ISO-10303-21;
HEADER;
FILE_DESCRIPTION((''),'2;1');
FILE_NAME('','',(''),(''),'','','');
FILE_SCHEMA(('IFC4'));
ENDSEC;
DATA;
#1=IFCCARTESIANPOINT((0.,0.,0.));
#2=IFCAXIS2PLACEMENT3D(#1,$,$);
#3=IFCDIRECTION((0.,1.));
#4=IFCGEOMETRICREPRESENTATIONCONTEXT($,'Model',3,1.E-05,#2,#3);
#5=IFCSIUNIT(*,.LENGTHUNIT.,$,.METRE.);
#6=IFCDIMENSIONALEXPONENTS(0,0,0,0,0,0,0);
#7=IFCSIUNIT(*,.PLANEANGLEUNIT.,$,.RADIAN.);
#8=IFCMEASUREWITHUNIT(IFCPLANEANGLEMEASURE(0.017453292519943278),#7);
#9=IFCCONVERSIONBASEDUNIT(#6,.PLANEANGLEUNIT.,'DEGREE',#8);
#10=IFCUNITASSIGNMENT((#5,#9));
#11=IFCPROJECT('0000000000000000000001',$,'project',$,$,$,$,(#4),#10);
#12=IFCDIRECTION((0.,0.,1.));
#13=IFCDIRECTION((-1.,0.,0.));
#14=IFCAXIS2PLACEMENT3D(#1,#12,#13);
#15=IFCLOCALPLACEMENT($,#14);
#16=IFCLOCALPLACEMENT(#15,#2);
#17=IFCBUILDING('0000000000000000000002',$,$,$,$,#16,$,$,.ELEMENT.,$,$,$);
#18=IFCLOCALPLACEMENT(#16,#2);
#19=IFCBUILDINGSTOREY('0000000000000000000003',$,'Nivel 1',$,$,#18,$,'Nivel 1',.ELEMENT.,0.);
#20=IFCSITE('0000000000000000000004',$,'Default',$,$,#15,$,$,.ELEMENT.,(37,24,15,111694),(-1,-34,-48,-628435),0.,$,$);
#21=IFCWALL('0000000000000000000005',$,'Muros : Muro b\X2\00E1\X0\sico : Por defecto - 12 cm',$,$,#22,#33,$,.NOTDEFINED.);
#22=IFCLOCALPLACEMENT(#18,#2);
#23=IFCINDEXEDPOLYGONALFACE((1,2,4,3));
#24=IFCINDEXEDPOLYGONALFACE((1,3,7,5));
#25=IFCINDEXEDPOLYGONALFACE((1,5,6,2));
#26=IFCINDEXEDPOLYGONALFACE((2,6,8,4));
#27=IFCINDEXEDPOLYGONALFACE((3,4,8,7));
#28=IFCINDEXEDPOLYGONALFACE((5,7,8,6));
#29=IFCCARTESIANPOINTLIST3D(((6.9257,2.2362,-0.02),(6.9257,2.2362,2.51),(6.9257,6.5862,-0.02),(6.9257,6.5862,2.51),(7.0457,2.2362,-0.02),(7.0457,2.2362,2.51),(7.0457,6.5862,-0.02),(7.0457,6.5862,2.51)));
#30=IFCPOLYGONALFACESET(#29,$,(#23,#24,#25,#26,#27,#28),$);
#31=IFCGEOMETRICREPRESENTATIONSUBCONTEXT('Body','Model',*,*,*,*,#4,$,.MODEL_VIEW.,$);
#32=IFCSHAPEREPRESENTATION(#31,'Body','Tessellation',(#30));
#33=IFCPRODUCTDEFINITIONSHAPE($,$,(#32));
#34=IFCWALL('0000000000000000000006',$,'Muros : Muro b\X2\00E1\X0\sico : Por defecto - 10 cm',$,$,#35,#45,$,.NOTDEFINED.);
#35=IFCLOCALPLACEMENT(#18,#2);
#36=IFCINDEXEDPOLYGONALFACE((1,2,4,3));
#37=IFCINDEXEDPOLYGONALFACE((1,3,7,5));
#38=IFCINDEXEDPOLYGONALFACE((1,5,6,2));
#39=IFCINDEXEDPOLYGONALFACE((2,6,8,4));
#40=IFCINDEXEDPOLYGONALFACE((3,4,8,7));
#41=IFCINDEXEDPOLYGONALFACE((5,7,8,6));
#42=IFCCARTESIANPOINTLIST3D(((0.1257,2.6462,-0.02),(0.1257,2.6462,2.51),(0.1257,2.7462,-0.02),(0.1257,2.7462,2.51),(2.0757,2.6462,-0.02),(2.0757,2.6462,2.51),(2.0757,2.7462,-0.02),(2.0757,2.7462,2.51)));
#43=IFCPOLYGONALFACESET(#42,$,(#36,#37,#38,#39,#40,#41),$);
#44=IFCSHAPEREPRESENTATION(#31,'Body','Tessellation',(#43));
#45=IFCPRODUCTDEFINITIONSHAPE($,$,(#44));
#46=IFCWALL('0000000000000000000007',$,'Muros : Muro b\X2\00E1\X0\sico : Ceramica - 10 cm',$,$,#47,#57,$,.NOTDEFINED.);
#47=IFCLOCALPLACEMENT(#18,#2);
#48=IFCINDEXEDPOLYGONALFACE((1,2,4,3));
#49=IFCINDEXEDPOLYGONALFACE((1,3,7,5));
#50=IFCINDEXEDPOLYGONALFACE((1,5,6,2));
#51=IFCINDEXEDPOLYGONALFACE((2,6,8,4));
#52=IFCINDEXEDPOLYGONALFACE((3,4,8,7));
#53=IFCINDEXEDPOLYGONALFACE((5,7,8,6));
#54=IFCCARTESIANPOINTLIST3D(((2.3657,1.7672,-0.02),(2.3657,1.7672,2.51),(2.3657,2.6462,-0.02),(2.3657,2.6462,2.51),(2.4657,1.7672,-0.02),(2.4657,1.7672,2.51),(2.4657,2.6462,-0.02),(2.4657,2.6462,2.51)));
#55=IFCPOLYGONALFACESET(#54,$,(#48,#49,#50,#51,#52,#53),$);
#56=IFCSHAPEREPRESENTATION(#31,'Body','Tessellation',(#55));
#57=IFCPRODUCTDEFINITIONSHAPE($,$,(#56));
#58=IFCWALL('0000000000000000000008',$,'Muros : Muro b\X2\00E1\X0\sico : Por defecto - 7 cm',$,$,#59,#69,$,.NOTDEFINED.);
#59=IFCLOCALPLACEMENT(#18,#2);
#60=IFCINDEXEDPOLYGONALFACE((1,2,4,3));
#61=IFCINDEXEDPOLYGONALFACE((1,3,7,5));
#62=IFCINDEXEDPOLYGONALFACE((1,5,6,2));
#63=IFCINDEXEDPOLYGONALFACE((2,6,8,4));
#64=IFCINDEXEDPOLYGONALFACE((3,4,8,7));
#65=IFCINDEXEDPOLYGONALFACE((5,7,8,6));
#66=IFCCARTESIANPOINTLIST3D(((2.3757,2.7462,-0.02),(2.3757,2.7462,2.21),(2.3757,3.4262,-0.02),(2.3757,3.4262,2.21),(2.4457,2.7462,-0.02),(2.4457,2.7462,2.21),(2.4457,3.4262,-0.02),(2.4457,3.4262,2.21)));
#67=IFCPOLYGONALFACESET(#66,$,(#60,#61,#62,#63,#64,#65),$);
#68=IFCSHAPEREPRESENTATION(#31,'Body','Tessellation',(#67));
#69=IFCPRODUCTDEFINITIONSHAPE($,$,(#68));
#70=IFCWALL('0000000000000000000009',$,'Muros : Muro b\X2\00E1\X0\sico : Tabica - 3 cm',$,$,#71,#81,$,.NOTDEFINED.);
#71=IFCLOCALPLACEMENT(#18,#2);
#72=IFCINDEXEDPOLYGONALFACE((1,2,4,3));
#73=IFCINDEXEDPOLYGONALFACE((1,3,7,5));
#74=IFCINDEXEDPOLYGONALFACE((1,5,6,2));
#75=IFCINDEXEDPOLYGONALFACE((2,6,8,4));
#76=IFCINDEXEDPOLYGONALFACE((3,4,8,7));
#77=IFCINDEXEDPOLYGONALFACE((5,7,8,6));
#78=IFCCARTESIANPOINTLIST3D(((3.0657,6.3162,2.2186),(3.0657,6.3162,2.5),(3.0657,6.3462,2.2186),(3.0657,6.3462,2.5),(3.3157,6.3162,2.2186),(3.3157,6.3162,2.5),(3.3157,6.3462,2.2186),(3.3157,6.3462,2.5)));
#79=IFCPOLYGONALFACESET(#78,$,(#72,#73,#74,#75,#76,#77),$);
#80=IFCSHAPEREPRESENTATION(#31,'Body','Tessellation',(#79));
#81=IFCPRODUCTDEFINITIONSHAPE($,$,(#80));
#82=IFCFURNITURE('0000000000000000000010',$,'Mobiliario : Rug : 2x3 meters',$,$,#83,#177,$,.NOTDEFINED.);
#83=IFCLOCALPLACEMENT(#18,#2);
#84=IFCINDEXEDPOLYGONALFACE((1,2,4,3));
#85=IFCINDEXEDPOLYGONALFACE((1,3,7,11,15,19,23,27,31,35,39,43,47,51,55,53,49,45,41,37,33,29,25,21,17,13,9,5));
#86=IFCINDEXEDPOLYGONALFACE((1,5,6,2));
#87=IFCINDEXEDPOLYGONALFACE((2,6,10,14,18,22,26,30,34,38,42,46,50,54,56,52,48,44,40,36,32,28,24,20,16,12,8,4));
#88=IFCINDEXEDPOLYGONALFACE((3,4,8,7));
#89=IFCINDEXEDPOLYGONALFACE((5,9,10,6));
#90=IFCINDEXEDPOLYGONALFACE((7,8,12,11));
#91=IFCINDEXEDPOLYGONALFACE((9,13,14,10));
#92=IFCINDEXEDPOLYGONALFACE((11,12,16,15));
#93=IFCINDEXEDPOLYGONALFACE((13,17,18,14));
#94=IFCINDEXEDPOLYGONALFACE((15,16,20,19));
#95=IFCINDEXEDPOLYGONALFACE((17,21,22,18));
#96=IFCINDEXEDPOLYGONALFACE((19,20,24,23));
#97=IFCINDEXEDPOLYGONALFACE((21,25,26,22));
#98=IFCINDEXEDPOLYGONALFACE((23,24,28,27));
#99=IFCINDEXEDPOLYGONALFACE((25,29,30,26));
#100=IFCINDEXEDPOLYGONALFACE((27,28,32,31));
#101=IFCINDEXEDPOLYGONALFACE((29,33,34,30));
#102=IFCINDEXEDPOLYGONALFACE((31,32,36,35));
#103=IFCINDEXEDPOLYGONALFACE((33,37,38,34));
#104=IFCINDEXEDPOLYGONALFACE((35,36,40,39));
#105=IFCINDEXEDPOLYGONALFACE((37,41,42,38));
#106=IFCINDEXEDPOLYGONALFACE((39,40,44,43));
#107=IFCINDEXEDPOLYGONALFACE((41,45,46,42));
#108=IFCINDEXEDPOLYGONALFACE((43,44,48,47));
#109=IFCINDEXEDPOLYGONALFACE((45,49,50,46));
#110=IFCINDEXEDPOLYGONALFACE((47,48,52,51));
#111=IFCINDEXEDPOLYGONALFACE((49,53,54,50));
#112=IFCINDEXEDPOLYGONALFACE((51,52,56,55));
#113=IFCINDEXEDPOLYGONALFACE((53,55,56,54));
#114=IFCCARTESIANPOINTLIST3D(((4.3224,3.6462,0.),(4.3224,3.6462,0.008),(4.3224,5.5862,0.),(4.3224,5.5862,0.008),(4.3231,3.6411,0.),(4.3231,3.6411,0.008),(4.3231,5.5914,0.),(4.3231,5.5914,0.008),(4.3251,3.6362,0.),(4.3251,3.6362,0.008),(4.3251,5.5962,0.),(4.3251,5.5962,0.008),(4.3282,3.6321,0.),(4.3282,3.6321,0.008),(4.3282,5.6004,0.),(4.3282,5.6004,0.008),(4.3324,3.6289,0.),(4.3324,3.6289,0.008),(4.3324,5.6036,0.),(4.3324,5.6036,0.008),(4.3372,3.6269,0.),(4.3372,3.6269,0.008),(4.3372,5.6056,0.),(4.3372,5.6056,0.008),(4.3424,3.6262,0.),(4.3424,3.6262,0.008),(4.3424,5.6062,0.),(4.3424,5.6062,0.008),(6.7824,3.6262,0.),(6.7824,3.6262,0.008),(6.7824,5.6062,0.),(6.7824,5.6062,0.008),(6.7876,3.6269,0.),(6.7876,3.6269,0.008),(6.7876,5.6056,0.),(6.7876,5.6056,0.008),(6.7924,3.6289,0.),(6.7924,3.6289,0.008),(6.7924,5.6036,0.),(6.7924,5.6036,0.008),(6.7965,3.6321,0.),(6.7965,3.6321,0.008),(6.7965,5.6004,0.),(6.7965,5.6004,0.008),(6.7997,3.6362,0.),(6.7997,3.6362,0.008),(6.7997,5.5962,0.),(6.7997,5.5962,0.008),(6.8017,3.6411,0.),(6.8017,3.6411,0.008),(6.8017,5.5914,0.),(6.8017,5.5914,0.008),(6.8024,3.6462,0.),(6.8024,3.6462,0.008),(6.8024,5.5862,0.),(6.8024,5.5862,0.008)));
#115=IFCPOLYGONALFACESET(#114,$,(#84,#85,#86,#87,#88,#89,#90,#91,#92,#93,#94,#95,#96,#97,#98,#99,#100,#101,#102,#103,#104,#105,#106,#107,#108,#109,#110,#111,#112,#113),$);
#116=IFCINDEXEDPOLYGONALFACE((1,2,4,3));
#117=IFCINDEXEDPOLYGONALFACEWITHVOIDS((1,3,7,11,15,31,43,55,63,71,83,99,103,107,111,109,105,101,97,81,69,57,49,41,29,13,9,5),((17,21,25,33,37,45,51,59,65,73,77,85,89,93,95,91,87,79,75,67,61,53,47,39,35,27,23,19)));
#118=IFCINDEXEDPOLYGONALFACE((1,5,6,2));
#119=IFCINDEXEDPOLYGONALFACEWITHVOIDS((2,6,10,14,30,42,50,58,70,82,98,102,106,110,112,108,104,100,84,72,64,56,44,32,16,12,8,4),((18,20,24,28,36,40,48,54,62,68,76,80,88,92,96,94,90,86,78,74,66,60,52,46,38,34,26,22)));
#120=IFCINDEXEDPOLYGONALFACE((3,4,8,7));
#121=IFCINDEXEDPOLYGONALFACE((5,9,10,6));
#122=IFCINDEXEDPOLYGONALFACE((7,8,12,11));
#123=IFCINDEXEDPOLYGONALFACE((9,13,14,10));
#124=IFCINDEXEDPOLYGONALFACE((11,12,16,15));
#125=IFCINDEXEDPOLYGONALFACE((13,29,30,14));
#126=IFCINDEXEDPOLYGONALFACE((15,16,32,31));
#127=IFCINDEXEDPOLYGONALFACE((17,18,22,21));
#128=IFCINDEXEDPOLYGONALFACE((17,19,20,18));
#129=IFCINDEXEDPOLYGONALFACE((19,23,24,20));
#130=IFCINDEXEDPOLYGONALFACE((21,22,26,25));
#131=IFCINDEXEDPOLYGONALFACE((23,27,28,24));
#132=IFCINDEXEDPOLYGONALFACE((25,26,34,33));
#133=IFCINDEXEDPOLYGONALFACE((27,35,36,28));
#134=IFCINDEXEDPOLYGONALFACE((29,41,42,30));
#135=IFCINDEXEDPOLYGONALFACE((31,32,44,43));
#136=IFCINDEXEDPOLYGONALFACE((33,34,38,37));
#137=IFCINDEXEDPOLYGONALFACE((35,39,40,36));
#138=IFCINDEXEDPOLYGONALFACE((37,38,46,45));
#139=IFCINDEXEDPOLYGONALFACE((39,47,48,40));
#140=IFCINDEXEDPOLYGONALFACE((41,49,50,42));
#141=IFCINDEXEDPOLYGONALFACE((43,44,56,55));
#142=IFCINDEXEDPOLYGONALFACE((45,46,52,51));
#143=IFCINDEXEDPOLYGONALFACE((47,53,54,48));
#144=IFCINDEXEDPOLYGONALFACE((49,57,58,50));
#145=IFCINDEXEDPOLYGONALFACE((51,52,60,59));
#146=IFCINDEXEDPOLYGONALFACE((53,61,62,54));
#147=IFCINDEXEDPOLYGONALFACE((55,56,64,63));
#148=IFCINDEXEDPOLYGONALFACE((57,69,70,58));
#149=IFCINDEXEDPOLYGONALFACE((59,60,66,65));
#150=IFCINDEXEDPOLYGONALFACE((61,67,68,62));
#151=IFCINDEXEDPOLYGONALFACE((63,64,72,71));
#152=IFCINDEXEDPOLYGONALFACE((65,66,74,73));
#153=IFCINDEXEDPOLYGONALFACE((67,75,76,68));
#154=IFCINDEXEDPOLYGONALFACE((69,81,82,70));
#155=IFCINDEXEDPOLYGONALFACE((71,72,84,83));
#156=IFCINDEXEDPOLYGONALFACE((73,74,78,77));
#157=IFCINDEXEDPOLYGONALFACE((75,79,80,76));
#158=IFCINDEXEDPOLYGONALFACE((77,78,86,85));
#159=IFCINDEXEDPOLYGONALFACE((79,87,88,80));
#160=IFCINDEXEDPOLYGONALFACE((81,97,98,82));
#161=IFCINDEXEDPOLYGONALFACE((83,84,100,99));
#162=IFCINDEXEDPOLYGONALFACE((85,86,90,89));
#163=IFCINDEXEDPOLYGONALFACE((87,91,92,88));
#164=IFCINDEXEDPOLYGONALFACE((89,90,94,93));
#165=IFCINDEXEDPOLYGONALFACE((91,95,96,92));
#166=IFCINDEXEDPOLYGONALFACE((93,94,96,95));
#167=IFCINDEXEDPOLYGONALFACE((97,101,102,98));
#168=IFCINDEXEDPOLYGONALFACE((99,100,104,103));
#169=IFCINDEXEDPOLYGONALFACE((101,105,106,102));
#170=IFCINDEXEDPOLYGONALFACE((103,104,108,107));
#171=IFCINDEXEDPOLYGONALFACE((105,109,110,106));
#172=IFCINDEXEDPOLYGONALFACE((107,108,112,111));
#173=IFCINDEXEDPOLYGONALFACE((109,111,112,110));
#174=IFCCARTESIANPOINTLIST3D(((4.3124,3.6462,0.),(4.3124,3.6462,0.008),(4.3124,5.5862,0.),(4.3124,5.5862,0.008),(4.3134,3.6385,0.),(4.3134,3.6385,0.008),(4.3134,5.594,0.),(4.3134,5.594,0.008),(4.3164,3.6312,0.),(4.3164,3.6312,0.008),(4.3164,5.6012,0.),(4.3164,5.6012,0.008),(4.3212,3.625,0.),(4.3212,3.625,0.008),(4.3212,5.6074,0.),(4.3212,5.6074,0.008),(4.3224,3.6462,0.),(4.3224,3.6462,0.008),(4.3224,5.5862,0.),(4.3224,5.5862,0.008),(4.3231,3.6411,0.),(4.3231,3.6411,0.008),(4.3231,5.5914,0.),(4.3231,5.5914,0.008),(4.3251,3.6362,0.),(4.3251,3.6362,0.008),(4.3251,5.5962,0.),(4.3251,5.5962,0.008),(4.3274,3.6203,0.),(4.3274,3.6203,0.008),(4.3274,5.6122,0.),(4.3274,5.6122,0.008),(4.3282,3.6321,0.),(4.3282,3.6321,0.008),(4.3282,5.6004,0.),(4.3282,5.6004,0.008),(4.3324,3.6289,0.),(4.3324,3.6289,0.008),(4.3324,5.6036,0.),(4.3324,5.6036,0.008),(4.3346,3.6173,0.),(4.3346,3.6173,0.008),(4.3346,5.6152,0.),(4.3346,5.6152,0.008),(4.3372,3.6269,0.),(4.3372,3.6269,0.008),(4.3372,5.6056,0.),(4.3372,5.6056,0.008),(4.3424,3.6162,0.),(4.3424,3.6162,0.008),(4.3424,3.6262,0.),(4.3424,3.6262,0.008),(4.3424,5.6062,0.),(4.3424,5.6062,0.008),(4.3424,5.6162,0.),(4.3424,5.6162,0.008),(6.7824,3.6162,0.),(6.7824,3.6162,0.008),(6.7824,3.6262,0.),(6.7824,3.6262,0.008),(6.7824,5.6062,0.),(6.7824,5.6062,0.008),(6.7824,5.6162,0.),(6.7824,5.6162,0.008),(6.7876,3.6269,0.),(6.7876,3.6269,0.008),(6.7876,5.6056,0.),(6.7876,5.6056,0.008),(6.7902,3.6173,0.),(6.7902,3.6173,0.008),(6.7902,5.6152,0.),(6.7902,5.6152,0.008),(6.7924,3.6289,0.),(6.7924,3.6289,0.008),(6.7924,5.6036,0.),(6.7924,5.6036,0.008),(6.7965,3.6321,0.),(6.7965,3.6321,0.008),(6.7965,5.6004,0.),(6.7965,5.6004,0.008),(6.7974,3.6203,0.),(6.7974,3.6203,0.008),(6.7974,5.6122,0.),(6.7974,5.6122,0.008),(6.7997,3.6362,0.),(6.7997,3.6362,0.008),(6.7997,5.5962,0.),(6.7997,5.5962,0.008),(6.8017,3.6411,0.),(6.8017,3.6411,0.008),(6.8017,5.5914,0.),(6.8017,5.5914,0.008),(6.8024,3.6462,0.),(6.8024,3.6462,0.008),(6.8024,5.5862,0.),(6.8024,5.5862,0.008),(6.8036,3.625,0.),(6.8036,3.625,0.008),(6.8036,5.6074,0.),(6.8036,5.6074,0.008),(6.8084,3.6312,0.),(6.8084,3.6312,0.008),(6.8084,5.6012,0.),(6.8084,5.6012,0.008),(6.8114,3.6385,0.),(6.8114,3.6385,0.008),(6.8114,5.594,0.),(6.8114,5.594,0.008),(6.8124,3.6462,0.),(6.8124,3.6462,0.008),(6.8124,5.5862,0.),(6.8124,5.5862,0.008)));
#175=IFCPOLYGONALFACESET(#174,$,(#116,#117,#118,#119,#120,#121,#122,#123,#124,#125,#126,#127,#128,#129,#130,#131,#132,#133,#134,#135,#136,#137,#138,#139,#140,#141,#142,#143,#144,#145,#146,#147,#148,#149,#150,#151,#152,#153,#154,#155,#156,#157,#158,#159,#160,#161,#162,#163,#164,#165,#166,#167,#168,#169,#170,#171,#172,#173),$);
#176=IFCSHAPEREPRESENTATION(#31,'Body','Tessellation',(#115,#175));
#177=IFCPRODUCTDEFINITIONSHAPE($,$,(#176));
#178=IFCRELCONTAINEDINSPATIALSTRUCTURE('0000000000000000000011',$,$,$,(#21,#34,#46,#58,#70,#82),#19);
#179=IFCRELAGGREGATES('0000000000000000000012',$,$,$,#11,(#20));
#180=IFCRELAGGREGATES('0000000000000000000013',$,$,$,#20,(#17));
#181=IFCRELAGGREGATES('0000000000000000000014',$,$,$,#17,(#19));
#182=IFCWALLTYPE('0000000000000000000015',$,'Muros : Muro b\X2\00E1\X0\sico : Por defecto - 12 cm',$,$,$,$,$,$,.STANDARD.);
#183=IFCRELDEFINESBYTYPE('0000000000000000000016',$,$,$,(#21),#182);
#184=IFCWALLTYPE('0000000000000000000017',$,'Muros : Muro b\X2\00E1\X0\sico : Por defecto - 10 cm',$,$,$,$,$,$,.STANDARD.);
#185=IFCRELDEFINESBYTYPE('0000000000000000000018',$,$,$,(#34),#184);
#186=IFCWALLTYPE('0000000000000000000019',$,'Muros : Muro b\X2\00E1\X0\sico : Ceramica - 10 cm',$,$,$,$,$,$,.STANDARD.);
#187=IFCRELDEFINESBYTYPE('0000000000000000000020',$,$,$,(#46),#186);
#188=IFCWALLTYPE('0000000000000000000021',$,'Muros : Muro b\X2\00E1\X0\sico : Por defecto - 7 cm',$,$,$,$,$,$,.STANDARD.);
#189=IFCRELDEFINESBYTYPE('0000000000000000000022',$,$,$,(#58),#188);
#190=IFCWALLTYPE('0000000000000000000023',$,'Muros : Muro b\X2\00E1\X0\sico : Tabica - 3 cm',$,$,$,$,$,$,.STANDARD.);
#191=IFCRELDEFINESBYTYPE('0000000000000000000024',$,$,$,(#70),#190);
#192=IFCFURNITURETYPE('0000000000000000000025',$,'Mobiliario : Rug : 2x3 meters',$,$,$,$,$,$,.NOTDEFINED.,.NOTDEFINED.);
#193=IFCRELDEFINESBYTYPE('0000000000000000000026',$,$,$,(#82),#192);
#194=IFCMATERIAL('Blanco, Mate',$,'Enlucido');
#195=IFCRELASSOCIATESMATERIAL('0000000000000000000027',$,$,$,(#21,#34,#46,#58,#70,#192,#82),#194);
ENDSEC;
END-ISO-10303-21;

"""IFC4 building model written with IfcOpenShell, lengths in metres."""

from ifc_helpers import new_model, entity, si_unit, converted_unit, direction, frame, origin, place, context, subcontext, project, spatial, line, arc, indexed_curve, outline, extrude, source, transform, mapped, material, type_object, type_shapes, element, save


model = new_model("IFC4")

# Units and contexts
model_context = context("Model", 3, precision=1e-05, world=origin(), true_north=direction((0.0, 1.0)))
body_context = subcontext(model_context, "Body", "Model", "MODEL_VIEW")
ifc_project = project(units=[si_unit("LENGTHUNIT", "METRE"), converted_unit("PLANEANGLEUNIT", "DEGREE", entity("IfcPlaneAngleMeasure", 0.017453292519943278), si_unit("PLANEANGLEUNIT", "RADIAN"), dimensions=[0, 0, 0, 0, 0, 0, 0])], contexts=[model_context])

# Site, building, storey
site_placement = place(None, frame((0.0, 0.0, 0.0), z_axis=(0.0, 0.0, 1.0), x_axis=(-1.0, 0.0, 0.0)))
site = spatial("IfcSite", under=ifc_project, at=site_placement, Name="Default", CompositionType="ELEMENT", RefLatitude=(37, 24, 15, 111694), RefLongitude=(-1, -34, -48, -628435), RefElevation=0.0)
building_placement = place(site_placement, origin())
building = spatial("IfcBuilding", under=site, at=building_placement, CompositionType="ELEMENT")
storey_placement = place(building_placement, origin())
storey = spatial("IfcBuildingStorey", under=building, at=storey_placement, Name="Nivel 1", LongName="Nivel 1", CompositionType="ELEMENT", Elevation=0.0)

# Walls
ifc_material_1 = material(Name="Blanco, Mate", Category="Enlucido")
wall_type_1 = type_object("IfcWallType", Name="Muros : Muro básico : Por defecto - 12 cm", PredefinedType="STANDARD")
wall_1_placement = place(storey_placement, frame((6.9857, 6.5862, -0.02), z_axis=(0.0, 0.0, 1.0), x_axis=(0.0, -1.0, 0.0)))
element("IfcWall", 1, at=wall_1_placement, inside=storey, type_object=wall_type_1, material=ifc_material_1, Name="Muros : Muro básico : Por defecto - 12 cm", PredefinedType="NOTDEFINED", context=body_context, shape_type="SweptSolid", body=[
    extrude(outline(indexed_curve([(4.35, 0.06), (0.0, 0.06), (0.0, -0.06), (4.35, -0.06), (4.35, 0.06)], self_intersect=False)), origin(), (0.0, 0.0, 1.0), 2.53),
])
wall_type_2 = type_object("IfcWallType", Name="Muros : Muro básico : Por defecto - 10 cm", PredefinedType="STANDARD")
wall_2_placement = place(storey_placement, frame((2.0757, 2.6962, -0.02), z_axis=(0.0, 0.0, 1.0), x_axis=(-1.0, 0.0, 0.0)))
element("IfcWall", 2, at=wall_2_placement, inside=storey, type_object=wall_type_2, material=ifc_material_1, Name="Muros : Muro básico : Por defecto - 10 cm", PredefinedType="NOTDEFINED", context=body_context, shape_type="SweptSolid", body=[
    extrude(outline(indexed_curve([(1.95, 0.05), (0.0, 0.05), (0.0, -0.05), (1.95, -0.05), (1.95, 0.05)], self_intersect=False)), origin(), (0.0, 0.0, 1.0), 2.53),
])
wall_type_3 = type_object("IfcWallType", Name="Muros : Muro básico : Ceramica - 10 cm", PredefinedType="STANDARD")
wall_3_placement = place(storey_placement, frame((2.4157, 2.6462, -0.02), z_axis=(0.0, 0.0, 1.0), x_axis=(0.0, -1.0, 0.0)))
element("IfcWall", 3, at=wall_3_placement, inside=storey, type_object=wall_type_3, material=ifc_material_1, Name="Muros : Muro básico : Ceramica - 10 cm", PredefinedType="NOTDEFINED", context=body_context, shape_type="SweptSolid", body=[
    extrude(outline(indexed_curve([(0.8791, 0.05), (0.0, 0.05), (0.0, -0.05), (0.8791, -0.05), (0.8791, 0.05)], self_intersect=False)), origin(), (0.0, 0.0, 1.0), 2.53),
])
wall_type_4 = type_object("IfcWallType", Name="Muros : Muro básico : Por defecto - 7 cm", PredefinedType="STANDARD")
wall_4_placement = place(storey_placement, frame((2.4107, 2.7462, -0.02), z_axis=(0.0, 0.0, 1.0), x_axis=(0.0, 1.0, 0.0)))
element("IfcWall", 4, at=wall_4_placement, inside=storey, type_object=wall_type_4, material=ifc_material_1, Name="Muros : Muro básico : Por defecto - 7 cm", PredefinedType="NOTDEFINED", context=body_context, shape_type="SweptSolid", body=[
    extrude(outline(indexed_curve([(0.68, 0.035), (0.0, 0.035), (0.0, -0.035), (0.68, -0.035), (0.68, 0.035)], self_intersect=False)), origin(), (0.0, 0.0, 1.0), 2.23),
])
wall_type_5 = type_object("IfcWallType", Name="Muros : Muro básico : Tabica - 3 cm", PredefinedType="STANDARD")
wall_5_placement = place(storey_placement, frame((3.0657, 6.3312, 2.2186)))
element("IfcWall", 5, at=wall_5_placement, inside=storey, type_object=wall_type_5, material=ifc_material_1, Name="Muros : Muro básico : Tabica - 3 cm", PredefinedType="NOTDEFINED", context=body_context, shape_type="SweptSolid", body=[
    extrude(outline(indexed_curve([(0.25, 0.015), (0.0, 0.015), (0.0, -0.015), (0.25, -0.015), (0.25, 0.015)], self_intersect=False)), origin(), (0.0, 0.0, 1.0), 0.2814),
])

# Furniture
furniture_type_1 = type_object("IfcFurnitureType", Name="Mobiliario : Rug : 2x3 meters", AssemblyPlace="NOTDEFINED", PredefinedType="NOTDEFINED", material=ifc_material_1)
shared_shape_1 = source(origin(), body_context, "Body", "SweptSolid", [
    extrude(outline(indexed_curve([(-0.97, -1.24), (0.97, -1.24), (0.9841, -1.2341), (0.99, -1.22), (0.99, 1.22), (0.9841, 1.2341), (0.97, 1.24), (-0.97, 1.24), (-0.9841, 1.2341), (-0.99, 1.22), (-0.99, -1.22), (-0.9841, -1.2341)], segments=[line(1, 2), arc(2, 3, 4), line(4, 5), arc(5, 6, 7), line(7, 8), arc(8, 9, 10), line(10, 11), arc(11, 12, 1)], self_intersect=False)), frame((0.0, 0.0, 0.0), z_axis=(0.0, 0.0, 1.0), x_axis=(-1.0, 0.0, 0.0)), (0.0, 0.0, 1.0), 0.008),
    extrude(outline(indexed_curve([(-0.97, -1.25), (0.97, -1.25), (0.9912, -1.2412), (1.0, -1.22), (1.0, 1.22), (0.9912, 1.2412), (0.97, 1.25), (-0.97, 1.25), (-0.9912, 1.2412), (-1.0, 1.22), (-1.0, -1.22), (-0.9912, -1.2412)], segments=[line(1, 2), arc(2, 3, 4), line(4, 5), arc(5, 6, 7), line(7, 8), arc(8, 9, 10), line(10, 11), arc(11, 12, 1)], self_intersect=False), holes=[indexed_curve([(-0.97, -1.24), (-0.9841, -1.2341), (-0.99, -1.22), (-0.99, 1.22), (-0.9841, 1.2341), (-0.97, 1.24), (0.97, 1.24), (0.9841, 1.2341), (0.99, 1.22), (0.99, -1.22), (0.9841, -1.2341), (0.97, -1.24)], segments=[arc(1, 2, 3), line(3, 4), arc(4, 5, 6), line(6, 7), arc(7, 8, 9), line(9, 10), arc(10, 11, 12), line(12, 1)], self_intersect=False)]), frame((0.0, 0.0, 0.0), z_axis=(0.0, 0.0, 1.0), x_axis=(-1.0, 0.0, 0.0)), (0.0, 0.0, 1.0), 0.008),
])
type_shapes(furniture_type_1, [shared_shape_1])
furniture_1_placement = place(storey_placement, frame((5.5624, 4.6162, 0.0), z_axis=(0.0, 0.0, 1.0), x_axis=(0.0, 1.0, 0.0)))
element("IfcFurniture", 6, at=furniture_1_placement, inside=storey, type_object=furniture_type_1, material=ifc_material_1, Name="Mobiliario : Rug : 2x3 meters", PredefinedType="NOTDEFINED", context=body_context, shape_type="MappedRepresentation", body=[
    mapped(shared_shape_1, transform((0.0, 0.0, 0.0), scale=1.0)),
])

save(model, "model.ifc")
